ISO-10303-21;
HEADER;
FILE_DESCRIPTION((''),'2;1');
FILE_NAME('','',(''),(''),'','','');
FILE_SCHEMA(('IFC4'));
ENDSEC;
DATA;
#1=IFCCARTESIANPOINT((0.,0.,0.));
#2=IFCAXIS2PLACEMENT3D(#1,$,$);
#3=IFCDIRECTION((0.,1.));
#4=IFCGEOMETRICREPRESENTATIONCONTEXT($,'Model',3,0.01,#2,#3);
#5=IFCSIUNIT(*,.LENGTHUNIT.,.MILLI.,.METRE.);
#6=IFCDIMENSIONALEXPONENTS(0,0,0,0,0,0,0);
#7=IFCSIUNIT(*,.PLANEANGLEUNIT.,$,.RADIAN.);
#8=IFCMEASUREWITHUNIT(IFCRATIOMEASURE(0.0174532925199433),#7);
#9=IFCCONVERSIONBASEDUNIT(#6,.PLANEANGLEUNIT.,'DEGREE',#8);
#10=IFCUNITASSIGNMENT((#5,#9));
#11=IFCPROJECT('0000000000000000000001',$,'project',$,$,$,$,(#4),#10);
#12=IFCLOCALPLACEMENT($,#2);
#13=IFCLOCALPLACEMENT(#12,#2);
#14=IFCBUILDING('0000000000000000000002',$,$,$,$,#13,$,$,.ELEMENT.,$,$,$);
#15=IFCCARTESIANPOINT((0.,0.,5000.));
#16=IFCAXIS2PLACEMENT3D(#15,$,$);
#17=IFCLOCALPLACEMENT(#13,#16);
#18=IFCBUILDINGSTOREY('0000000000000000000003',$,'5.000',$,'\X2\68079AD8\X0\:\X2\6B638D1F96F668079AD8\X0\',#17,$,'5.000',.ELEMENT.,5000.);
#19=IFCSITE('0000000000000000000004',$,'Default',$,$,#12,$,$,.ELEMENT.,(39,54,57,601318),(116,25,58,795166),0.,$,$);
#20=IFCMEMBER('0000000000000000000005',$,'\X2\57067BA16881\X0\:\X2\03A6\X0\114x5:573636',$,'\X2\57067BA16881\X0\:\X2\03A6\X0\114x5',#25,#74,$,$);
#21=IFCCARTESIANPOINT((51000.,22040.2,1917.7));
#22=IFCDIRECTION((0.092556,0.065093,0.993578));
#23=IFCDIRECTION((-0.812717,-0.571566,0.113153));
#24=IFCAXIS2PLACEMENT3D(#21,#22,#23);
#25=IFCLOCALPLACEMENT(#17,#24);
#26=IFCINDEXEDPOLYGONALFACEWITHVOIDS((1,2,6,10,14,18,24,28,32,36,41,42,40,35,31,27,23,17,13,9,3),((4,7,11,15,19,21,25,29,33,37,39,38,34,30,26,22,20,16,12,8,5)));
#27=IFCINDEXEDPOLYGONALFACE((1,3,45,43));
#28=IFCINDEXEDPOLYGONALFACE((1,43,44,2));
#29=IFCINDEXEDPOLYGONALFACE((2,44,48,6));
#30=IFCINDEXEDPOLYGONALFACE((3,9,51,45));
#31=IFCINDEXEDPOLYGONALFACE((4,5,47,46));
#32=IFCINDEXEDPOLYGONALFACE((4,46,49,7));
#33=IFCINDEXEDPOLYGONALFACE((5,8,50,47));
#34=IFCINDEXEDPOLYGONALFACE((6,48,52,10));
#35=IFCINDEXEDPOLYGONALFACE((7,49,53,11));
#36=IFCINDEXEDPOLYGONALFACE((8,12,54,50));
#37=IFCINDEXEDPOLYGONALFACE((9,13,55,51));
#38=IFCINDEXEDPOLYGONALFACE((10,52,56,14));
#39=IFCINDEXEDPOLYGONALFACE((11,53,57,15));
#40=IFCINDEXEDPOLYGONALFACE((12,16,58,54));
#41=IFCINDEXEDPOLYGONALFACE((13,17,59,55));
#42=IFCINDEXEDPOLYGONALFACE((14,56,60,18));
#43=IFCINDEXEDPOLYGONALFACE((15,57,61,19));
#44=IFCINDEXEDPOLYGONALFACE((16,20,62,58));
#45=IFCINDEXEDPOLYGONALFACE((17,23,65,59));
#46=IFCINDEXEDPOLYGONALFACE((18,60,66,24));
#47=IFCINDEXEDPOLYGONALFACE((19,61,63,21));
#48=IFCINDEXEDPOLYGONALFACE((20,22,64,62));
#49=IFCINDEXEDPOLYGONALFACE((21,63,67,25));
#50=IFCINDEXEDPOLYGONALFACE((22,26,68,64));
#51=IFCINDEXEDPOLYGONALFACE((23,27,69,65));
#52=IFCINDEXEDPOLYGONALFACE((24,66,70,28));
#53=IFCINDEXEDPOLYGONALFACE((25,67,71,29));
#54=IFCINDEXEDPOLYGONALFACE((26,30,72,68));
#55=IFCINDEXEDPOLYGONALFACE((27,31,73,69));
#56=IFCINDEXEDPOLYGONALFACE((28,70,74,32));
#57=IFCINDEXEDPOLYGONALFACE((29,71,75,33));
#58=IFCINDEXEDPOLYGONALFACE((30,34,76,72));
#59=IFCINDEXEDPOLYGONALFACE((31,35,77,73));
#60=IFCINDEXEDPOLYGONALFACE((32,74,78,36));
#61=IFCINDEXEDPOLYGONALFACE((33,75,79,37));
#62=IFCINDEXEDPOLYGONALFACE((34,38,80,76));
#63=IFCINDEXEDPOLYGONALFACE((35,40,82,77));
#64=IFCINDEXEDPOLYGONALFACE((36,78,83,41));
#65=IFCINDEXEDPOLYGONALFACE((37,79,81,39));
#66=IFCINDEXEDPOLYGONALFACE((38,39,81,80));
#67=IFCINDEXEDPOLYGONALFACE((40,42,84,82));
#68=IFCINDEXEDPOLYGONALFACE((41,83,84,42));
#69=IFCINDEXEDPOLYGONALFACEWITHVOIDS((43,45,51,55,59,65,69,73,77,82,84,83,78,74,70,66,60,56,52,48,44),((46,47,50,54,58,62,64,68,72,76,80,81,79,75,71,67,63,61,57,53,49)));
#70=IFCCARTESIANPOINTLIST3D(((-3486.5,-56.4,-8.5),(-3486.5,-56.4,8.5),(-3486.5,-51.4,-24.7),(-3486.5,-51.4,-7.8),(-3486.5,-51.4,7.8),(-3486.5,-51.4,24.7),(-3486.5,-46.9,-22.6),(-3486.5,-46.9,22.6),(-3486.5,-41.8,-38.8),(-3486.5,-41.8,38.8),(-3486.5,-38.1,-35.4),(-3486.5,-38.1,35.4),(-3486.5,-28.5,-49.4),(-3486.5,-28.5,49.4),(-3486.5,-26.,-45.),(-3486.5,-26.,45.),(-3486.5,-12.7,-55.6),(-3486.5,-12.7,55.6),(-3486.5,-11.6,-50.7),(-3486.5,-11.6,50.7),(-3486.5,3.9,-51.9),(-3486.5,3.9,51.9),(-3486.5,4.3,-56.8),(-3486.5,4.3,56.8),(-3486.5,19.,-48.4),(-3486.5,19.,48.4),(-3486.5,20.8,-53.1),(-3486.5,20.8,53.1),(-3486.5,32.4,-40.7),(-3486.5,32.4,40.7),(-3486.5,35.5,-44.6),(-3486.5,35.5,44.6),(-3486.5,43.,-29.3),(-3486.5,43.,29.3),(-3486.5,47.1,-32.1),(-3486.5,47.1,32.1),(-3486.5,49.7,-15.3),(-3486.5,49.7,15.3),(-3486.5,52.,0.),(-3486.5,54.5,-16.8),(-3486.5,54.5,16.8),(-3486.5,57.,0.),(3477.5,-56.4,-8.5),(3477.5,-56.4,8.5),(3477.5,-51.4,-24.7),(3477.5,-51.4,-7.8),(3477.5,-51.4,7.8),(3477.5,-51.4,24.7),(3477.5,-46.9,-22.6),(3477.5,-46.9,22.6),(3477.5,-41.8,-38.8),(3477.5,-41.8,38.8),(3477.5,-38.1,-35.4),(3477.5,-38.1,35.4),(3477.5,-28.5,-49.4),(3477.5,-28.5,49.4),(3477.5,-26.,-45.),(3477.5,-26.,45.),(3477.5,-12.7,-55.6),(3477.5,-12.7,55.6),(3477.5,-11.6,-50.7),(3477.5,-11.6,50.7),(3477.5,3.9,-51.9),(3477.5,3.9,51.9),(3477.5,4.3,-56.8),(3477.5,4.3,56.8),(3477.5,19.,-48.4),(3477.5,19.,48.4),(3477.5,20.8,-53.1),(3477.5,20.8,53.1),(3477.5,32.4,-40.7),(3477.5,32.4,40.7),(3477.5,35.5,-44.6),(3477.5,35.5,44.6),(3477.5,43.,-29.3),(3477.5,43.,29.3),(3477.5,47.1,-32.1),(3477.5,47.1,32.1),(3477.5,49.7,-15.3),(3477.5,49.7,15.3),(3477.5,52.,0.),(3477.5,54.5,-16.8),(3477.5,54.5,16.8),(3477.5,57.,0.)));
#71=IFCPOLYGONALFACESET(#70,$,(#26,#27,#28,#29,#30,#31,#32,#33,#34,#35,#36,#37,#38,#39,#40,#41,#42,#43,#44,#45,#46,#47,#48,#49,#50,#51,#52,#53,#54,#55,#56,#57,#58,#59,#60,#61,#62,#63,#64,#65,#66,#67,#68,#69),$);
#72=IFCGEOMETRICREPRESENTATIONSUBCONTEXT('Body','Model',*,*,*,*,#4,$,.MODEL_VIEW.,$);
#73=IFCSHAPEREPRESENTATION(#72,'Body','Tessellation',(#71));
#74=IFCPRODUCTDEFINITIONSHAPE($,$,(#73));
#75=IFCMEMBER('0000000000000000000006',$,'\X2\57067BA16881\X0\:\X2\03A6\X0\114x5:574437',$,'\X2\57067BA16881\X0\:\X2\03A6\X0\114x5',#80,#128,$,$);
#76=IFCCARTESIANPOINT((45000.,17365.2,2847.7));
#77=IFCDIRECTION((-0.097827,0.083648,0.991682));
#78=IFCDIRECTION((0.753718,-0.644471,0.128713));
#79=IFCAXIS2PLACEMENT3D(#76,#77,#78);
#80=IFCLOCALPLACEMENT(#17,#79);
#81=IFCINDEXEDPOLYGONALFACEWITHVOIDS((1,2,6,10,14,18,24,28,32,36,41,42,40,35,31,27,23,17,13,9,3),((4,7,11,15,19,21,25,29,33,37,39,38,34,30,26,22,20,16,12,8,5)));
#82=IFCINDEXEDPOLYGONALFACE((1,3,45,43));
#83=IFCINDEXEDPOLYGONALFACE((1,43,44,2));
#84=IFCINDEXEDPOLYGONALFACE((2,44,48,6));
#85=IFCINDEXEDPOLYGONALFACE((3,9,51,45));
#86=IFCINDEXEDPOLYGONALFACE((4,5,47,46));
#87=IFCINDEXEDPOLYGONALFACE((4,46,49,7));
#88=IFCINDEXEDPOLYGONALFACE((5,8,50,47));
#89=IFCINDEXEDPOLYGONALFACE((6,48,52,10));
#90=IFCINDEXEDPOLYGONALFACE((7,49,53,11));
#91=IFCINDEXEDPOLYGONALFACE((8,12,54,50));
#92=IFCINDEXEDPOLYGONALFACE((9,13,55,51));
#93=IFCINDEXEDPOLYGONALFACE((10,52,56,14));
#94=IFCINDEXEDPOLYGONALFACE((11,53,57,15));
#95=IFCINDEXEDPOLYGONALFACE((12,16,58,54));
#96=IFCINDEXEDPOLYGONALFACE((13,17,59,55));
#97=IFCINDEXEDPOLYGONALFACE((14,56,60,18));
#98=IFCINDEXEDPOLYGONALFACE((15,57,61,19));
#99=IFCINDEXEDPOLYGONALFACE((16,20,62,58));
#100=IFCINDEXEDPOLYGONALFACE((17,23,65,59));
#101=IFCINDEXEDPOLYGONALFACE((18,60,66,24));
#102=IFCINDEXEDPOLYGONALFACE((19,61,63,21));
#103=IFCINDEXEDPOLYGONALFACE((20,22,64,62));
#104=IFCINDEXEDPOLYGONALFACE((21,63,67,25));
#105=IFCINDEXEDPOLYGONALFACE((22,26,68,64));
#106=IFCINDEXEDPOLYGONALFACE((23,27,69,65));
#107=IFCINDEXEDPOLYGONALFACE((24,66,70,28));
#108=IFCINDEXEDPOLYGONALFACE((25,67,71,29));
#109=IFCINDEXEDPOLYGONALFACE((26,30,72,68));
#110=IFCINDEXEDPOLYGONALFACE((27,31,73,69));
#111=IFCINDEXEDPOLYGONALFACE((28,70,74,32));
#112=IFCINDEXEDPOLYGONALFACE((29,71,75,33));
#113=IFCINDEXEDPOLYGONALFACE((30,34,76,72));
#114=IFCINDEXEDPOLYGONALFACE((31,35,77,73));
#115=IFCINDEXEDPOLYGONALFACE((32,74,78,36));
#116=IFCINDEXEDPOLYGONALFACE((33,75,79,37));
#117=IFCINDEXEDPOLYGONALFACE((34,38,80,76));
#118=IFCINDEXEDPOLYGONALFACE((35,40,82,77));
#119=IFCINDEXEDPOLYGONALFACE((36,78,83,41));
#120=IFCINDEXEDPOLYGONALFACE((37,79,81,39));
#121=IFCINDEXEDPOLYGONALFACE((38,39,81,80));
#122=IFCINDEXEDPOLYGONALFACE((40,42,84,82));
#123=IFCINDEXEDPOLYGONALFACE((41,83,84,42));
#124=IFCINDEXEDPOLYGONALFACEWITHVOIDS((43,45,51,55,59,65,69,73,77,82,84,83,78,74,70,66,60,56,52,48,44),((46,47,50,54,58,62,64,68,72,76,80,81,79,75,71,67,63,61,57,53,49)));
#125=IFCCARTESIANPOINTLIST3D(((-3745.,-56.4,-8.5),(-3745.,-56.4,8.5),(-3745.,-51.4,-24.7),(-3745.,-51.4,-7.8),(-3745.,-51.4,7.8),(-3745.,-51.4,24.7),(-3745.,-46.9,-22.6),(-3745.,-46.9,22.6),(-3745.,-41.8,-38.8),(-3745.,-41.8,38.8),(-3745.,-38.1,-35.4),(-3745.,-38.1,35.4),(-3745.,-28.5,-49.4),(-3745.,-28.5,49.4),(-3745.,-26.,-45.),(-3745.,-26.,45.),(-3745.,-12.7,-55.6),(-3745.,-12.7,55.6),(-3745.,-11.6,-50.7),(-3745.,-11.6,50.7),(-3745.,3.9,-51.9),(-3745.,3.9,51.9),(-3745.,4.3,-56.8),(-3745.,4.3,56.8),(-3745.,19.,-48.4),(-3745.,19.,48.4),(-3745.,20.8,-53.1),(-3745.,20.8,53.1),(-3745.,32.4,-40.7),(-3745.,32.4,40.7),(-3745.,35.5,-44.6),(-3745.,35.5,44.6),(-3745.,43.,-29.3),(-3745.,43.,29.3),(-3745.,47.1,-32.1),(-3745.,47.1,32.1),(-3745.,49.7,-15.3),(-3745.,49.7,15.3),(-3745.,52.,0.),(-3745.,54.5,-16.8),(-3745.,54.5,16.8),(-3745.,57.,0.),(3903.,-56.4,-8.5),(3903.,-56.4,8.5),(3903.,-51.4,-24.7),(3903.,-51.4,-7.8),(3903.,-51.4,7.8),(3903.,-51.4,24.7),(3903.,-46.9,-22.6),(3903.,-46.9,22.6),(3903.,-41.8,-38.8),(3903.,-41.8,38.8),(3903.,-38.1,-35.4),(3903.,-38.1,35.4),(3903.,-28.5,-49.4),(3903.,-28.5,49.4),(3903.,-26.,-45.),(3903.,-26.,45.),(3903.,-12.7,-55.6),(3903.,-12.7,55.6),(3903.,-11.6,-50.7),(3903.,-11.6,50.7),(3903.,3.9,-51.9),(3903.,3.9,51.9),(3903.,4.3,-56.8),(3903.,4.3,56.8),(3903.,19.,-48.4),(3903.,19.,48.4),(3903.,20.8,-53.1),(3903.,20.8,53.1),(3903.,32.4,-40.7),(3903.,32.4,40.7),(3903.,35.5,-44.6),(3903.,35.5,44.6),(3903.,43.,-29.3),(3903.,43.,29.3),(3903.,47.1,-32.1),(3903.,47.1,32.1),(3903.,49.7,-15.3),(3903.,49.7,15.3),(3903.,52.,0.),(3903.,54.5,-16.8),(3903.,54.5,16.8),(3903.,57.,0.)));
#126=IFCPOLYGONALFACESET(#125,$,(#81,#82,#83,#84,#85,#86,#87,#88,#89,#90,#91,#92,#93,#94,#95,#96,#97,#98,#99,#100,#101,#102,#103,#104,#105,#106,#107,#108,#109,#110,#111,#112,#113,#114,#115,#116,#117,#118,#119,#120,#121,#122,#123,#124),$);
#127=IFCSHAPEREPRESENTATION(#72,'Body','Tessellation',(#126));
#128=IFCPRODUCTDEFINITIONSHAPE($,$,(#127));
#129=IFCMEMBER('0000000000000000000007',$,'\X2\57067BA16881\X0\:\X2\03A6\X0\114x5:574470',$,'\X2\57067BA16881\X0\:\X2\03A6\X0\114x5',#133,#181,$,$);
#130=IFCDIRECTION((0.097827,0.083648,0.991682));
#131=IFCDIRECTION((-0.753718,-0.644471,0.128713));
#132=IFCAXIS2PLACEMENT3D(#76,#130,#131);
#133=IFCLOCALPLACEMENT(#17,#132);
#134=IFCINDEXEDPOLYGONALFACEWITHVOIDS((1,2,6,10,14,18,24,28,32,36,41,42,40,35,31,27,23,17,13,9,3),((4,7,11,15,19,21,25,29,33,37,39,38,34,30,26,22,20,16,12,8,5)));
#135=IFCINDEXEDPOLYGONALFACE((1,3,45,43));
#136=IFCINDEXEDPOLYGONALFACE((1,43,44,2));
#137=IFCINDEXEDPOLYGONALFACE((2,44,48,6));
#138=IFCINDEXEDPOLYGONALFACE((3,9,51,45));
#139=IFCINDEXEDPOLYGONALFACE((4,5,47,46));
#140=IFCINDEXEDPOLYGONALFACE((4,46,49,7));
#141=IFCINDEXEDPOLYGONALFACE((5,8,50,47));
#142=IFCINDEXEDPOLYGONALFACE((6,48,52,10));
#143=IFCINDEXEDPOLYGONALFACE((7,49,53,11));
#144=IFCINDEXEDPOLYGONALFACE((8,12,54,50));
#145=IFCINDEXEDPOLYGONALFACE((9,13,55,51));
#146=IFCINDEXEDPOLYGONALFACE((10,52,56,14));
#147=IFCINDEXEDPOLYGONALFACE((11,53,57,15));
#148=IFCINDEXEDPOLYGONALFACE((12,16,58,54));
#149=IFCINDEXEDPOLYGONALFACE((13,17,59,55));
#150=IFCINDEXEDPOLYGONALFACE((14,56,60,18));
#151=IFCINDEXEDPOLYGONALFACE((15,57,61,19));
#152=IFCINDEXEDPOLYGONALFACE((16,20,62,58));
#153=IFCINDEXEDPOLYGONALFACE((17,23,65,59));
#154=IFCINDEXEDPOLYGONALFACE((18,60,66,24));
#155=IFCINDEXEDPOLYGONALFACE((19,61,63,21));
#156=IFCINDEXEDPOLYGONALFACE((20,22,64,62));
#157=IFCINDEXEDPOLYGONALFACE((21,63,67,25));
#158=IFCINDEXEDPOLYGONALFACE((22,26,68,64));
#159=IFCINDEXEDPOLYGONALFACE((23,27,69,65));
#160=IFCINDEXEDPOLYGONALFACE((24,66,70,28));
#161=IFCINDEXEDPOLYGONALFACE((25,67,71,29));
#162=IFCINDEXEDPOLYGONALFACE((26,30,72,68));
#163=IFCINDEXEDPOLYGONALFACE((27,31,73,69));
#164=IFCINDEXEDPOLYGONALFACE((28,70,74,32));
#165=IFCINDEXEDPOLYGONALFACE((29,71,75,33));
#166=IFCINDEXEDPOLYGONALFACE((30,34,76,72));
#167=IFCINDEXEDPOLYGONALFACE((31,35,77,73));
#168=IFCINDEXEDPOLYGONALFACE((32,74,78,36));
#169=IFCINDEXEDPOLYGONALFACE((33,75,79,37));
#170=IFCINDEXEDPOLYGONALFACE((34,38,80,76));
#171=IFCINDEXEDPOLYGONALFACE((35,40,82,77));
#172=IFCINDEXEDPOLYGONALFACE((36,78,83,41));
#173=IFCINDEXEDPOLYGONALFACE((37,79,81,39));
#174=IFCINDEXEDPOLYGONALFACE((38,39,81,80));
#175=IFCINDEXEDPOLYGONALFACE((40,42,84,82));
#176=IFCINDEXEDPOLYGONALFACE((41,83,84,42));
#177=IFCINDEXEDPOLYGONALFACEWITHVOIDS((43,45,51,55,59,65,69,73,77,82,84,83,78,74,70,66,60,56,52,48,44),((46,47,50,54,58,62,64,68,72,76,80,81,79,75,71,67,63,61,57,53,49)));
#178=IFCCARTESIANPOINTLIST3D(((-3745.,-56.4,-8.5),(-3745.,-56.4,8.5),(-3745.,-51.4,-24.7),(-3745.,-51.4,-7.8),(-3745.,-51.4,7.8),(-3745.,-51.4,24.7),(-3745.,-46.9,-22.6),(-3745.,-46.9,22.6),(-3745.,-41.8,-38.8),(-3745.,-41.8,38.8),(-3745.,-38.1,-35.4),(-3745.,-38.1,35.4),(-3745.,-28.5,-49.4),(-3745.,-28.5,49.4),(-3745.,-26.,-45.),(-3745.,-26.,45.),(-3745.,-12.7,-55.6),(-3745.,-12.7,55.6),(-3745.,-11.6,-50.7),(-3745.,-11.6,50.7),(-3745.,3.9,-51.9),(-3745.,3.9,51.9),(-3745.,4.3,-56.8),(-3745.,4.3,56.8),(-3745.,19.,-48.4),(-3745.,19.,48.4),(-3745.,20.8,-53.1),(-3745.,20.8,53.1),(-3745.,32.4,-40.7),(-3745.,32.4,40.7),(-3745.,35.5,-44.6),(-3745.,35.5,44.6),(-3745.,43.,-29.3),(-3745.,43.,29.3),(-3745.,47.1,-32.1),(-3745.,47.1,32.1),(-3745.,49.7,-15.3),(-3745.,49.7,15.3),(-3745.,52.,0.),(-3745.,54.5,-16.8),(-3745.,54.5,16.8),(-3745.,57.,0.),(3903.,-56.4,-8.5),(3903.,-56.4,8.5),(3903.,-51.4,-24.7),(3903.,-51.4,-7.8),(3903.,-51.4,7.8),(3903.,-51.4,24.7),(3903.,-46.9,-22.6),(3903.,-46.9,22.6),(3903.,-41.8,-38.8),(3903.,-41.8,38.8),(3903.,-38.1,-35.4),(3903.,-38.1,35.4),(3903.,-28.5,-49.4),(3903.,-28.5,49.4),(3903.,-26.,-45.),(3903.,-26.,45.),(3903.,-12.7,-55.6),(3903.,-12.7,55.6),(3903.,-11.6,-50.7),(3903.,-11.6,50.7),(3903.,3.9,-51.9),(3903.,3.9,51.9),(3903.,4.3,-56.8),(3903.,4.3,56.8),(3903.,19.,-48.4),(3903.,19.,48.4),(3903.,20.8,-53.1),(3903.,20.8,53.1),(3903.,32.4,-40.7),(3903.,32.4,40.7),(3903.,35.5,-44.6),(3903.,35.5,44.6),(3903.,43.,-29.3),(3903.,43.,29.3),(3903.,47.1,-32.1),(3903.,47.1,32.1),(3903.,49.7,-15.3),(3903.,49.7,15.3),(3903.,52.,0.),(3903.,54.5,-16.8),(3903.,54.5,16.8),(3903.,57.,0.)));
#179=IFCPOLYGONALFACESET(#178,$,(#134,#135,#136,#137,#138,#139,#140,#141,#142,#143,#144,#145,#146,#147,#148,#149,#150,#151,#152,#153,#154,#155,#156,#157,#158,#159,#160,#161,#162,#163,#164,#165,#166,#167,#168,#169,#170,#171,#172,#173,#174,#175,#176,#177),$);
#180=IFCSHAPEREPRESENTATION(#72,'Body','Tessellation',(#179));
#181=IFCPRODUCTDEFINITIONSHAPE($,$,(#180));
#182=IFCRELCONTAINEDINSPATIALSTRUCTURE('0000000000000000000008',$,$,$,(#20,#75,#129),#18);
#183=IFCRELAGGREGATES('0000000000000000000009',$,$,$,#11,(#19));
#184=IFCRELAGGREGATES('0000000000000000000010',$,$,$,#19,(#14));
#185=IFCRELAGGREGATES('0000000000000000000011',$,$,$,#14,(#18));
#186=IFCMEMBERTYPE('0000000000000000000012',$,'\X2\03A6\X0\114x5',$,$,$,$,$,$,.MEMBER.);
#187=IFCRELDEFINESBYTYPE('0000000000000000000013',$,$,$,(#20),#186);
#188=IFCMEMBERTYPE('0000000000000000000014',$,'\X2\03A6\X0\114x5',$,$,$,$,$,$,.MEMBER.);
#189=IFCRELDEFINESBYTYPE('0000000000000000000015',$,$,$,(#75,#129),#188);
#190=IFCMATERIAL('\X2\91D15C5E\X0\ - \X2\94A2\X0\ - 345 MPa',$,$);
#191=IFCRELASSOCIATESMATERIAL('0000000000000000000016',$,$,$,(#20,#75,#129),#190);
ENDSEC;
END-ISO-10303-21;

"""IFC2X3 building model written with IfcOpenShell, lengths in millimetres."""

from ifc_helpers import new_model, entity, si_unit, converted_unit, direction, frame, frame_2d, origin, place, context, subcontext, project, spatial, hollow_circle, extrude, source, transform, mapped, material, type_object, type_shapes, element, save


model = new_model("IFC2X3")

# Units and contexts
model_context = context("Model", 3, precision=0.01, world=origin(), true_north=direction((0.0, 1.0)))
body_context = subcontext(model_context, "Body", "Model", "MODEL_VIEW")
ifc_project = project(units=[si_unit("LENGTHUNIT", "METRE", prefix="MILLI"), converted_unit("PLANEANGLEUNIT", "DEGREE", entity("IfcRatioMeasure", 0.0174532925199433), si_unit("PLANEANGLEUNIT", "RADIAN"), dimensions=[0, 0, 0, 0, 0, 0, 0])], contexts=[model_context])

# Site, building, storey
site_placement = place(None, origin())
site = spatial("IfcSite", under=ifc_project, at=site_placement, Name="Default", CompositionType="ELEMENT", RefLatitude=(39, 54, 57, 601318), RefLongitude=(116, 25, 58, 795166), RefElevation=0.0)
building_placement = place(site_placement, origin())
building = spatial("IfcBuilding", under=site, at=building_placement, CompositionType="ELEMENT")
storey_placement = place(building_placement, frame((0.0, 0.0, 5000.0)))
storey = spatial("IfcBuildingStorey", under=building, at=storey_placement, Name="5.000", ObjectType="标高:正负零标高", LongName="5.000", CompositionType="ELEMENT", Elevation=5000.0)

# Members
ifc_material_1 = material(Name="金属 - 钢 - 345 MPa")
member_type_1 = type_object("IfcMemberType", Name="Φ114x5", PredefinedType="MEMBER")
shared_shape_1 = source(origin(), body_context, "Body", "SweptSolid", [
    extrude(hollow_circle(Radius=57.0, WallThickness=5.0, at=frame_2d((0.0, 0.0), x_axis=(1.0, 0.0))), frame((-3486.5, 0.0, 0.0), z_axis=(1.0, 0.0, 0.0), x_axis=(0.0, 1.0, 0.0)), (0.0, 0.0, 1.0), 6964.0),
])
type_shapes(member_type_1, [shared_shape_1])
for number, where, z_axis, x_axis, name in (
    (1, (51000.0, 22040.2, 1917.7), (0.092556, 0.065093, 0.993578), (-0.812717, -0.571566, 0.113153), "圆管梁:Φ114x5:573636"),
):
    element("IfcMember", number, at=place(storey_placement, frame(where, z_axis=z_axis, x_axis=x_axis)), inside=storey, type_object=member_type_1, material=ifc_material_1, Name=name, ObjectType="圆管梁:Φ114x5", context=body_context, shape_type="MappedRepresentation", body=[
        mapped(shared_shape_1, transform((0.0, 0.0, 0.0), scale=1.0)),
    ])
member_type_2 = type_object("IfcMemberType", Name="Φ114x5", PredefinedType="MEMBER")
shared_shape_2 = source(origin(), body_context, "Body", "SweptSolid", [
    extrude(hollow_circle(Radius=57.0, WallThickness=5.0, at=frame_2d((0.0, 0.0), x_axis=(1.0, 0.0))), frame((-3745.0, 0.0, 0.0), z_axis=(1.0, 0.0, 0.0), x_axis=(0.0, 1.0, 0.0)), (0.0, 0.0, 1.0), 7648.0),
])
type_shapes(member_type_2, [shared_shape_2])
for number, where, z_axis, x_axis, name in (
    (2, (45000.0, 17365.2, 2847.7), (-0.097827, 0.083648, 0.991682), (0.753718, -0.644471, 0.128713), "圆管梁:Φ114x5:574437"),
    (3, (45000.0, 17365.2, 2847.7), (0.097827, 0.083648, 0.991682), (-0.753718, -0.644471, 0.128713), "圆管梁:Φ114x5:574470"),
):
    element("IfcMember", number, at=place(storey_placement, frame(where, z_axis=z_axis, x_axis=x_axis)), inside=storey, type_object=member_type_2, material=ifc_material_1, Name=name, ObjectType="圆管梁:Φ114x5", context=body_context, shape_type="MappedRepresentation", body=[
        mapped(shared_shape_2, transform((0.0, 0.0, 0.0), scale=1.0)),
    ])

save(model, "model.ifc")
